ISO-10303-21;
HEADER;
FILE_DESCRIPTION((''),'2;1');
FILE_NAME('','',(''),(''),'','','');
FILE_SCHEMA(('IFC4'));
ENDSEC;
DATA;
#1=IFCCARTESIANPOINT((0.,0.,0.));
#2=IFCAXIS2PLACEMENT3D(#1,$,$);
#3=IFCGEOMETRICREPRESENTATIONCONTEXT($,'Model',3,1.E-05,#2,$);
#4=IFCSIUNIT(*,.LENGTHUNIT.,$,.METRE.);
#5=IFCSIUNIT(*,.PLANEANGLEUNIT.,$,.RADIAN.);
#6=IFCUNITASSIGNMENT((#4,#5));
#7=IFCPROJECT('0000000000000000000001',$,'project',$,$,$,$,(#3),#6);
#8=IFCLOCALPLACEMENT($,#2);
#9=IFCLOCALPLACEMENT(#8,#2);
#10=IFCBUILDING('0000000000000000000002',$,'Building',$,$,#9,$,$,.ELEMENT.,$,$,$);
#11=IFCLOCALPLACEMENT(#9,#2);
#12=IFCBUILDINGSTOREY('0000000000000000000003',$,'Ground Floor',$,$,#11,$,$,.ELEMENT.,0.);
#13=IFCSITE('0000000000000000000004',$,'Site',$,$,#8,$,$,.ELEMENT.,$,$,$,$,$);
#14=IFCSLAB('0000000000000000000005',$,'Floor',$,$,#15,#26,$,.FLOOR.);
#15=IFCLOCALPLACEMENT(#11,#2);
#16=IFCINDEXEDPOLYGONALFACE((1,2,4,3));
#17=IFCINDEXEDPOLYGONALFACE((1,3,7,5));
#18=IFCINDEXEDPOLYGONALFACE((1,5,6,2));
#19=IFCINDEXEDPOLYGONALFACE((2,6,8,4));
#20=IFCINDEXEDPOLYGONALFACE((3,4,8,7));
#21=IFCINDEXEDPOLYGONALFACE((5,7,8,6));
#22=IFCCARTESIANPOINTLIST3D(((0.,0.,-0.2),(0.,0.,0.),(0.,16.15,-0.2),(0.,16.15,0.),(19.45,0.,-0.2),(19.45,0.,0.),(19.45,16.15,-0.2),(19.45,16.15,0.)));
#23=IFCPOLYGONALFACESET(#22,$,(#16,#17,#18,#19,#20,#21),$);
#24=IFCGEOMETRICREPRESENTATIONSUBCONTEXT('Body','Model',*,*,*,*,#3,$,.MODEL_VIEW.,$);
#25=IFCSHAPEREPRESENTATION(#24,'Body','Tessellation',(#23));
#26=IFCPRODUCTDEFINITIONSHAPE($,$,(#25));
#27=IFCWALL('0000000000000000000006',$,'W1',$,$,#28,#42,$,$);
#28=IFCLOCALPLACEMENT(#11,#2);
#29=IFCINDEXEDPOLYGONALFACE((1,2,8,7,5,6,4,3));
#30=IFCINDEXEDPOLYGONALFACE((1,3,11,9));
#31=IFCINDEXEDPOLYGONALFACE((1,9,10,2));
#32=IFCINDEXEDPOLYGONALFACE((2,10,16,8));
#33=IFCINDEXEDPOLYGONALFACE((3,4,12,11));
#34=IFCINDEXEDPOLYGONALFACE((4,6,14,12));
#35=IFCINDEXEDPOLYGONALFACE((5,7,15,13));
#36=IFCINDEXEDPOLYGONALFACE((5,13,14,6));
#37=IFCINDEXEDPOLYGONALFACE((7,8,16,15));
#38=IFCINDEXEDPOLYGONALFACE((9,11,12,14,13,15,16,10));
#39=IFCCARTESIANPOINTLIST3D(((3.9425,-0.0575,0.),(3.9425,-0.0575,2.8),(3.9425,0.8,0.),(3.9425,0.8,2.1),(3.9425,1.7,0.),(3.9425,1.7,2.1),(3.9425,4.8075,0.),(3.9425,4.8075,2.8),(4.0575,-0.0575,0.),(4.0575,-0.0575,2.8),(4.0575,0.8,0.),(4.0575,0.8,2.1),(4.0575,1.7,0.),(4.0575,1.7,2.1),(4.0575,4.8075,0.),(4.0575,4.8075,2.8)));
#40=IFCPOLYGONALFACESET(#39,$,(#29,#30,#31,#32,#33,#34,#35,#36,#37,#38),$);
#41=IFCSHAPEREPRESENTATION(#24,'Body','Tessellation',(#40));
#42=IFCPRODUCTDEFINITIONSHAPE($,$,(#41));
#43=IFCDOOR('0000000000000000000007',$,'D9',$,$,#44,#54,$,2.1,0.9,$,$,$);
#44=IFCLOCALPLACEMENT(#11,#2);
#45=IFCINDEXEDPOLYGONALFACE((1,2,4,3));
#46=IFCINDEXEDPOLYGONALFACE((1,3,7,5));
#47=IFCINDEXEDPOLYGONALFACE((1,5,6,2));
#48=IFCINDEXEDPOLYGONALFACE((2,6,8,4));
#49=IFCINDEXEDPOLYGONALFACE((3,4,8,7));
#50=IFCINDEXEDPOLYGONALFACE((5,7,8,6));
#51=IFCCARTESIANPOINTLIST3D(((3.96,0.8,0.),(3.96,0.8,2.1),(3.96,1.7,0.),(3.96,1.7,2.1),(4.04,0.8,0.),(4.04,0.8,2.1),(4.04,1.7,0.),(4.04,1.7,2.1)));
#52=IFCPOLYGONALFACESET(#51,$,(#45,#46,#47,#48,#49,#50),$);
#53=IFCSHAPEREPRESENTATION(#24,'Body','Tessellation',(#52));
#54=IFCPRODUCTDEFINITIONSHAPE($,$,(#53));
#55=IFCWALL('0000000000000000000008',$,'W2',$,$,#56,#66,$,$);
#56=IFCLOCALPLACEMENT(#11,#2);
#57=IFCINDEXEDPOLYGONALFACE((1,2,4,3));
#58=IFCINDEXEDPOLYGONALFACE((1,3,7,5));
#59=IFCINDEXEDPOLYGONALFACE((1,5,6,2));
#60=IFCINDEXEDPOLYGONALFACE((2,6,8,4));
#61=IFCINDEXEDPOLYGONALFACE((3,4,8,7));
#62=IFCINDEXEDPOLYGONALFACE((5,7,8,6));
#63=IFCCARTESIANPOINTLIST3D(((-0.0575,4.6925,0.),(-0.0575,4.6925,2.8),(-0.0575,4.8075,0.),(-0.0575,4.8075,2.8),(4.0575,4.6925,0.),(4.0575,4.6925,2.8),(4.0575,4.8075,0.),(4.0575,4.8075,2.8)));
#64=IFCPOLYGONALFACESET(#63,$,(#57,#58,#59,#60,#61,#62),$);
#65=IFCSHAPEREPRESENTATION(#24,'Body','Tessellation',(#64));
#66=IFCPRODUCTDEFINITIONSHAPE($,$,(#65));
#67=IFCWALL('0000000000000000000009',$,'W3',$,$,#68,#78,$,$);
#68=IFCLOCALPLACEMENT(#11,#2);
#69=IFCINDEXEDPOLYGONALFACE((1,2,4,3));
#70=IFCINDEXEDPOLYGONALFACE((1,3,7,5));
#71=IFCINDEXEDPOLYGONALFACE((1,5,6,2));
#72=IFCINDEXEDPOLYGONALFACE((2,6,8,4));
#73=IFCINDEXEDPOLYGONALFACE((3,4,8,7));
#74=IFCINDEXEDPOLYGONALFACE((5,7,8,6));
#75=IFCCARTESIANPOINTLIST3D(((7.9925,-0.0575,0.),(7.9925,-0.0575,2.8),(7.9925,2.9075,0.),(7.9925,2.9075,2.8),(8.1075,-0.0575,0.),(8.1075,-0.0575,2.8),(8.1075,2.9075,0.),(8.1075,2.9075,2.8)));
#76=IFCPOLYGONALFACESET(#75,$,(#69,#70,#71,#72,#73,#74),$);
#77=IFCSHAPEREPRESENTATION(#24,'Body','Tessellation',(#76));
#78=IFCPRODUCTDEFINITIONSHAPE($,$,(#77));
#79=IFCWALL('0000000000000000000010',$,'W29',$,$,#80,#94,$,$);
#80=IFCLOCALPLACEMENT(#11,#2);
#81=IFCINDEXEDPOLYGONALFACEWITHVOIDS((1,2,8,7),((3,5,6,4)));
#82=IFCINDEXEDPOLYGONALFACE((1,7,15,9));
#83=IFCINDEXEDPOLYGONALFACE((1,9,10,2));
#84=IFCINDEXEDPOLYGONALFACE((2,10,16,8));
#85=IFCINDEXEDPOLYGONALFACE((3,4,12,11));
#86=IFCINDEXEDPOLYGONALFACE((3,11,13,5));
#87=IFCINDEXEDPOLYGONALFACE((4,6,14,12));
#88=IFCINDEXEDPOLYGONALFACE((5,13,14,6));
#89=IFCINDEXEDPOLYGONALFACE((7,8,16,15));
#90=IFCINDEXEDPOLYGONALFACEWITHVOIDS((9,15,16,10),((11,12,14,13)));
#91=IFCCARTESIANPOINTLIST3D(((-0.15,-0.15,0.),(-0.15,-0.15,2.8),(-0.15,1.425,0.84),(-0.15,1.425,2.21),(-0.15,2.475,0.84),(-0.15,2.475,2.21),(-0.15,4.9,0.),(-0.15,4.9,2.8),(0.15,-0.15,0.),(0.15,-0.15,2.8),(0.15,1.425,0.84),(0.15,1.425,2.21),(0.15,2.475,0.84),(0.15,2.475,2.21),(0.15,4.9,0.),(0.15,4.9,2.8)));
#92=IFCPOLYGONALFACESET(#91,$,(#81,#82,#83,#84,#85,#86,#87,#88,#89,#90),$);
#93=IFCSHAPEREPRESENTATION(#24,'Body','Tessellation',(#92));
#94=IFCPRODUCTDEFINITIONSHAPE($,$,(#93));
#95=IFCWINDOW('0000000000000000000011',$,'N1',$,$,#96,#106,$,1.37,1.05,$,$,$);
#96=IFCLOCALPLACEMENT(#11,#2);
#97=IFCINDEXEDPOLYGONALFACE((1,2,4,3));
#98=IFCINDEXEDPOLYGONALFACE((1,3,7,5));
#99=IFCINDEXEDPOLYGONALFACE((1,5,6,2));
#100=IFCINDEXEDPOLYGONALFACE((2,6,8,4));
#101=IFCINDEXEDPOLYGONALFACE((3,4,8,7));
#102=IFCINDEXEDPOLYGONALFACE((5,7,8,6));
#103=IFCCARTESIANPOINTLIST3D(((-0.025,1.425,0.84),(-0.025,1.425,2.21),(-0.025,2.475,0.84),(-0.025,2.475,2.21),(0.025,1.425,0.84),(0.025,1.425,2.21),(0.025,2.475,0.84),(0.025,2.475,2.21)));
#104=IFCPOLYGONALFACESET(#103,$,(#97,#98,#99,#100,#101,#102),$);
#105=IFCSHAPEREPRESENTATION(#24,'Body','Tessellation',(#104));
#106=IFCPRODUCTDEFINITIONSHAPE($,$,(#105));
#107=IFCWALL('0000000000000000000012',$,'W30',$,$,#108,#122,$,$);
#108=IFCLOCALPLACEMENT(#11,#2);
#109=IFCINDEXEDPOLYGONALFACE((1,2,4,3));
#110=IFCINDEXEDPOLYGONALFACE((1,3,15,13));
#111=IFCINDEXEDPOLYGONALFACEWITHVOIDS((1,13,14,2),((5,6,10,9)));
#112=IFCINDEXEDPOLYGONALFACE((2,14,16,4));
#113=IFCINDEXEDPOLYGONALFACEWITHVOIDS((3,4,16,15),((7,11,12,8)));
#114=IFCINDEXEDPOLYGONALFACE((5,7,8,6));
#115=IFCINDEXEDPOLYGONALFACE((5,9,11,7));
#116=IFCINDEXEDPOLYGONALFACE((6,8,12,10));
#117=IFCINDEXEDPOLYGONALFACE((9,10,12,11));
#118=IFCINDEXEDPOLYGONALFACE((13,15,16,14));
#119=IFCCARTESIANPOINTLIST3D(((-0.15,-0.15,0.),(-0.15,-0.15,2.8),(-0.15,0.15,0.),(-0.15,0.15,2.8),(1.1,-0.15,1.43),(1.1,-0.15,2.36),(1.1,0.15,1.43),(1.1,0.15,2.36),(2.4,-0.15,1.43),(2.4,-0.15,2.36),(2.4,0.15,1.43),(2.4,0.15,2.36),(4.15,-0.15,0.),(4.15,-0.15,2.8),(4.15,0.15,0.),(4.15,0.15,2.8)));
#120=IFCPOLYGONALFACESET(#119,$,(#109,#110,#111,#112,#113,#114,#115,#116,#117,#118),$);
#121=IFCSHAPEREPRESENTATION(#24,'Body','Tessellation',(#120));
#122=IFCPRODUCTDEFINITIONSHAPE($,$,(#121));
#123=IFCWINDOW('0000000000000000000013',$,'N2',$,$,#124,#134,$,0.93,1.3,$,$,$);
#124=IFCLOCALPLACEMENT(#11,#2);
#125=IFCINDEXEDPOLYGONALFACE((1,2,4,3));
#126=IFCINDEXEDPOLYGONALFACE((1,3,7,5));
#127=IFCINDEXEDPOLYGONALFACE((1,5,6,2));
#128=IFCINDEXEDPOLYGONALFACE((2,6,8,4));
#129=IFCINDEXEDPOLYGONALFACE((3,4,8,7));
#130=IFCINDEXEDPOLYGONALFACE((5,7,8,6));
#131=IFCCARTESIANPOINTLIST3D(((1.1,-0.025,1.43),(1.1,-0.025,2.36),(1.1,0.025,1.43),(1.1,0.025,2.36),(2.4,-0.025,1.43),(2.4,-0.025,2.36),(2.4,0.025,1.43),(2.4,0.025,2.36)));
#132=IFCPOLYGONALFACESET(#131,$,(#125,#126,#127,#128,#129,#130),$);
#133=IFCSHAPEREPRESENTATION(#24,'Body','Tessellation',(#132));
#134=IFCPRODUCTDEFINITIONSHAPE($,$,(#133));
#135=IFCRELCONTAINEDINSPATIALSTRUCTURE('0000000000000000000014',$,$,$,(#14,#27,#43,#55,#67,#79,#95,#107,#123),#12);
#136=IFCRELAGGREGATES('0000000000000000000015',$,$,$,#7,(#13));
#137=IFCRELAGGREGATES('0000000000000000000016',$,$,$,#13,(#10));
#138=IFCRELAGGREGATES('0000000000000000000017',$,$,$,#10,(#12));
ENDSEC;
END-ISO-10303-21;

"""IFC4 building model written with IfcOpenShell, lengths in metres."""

from ifc_helpers import new_model, si_unit, frame, frame_2d, origin, origin_2d, place, context, subcontext, project, spatial, polyline, rectangle, outline, extrude, element, fill, save


model = new_model("IFC4")

# Units and contexts
model_context = context("Model", 3, precision=1e-05, world=origin())
body_context = subcontext(model_context, "Body", "Model", "MODEL_VIEW")
ifc_project = project(units=[si_unit("LENGTHUNIT", "METRE"), si_unit("PLANEANGLEUNIT", "RADIAN")], contexts=[model_context])

# Site, building, storey
site_placement = place(None, origin())
site = spatial("IfcSite", under=ifc_project, at=site_placement, Name="Site", CompositionType="ELEMENT")
building_placement = place(site_placement, origin())
building = spatial("IfcBuilding", under=site, at=building_placement, Name="Building", CompositionType="ELEMENT")
storey_placement = place(building_placement, origin())
storey = spatial("IfcBuildingStorey", under=building, at=storey_placement, Name="Ground Floor", CompositionType="ELEMENT", Elevation=0.0)

# Slab
slab_placement = place(storey_placement, origin())
element("IfcSlab", 1, at=slab_placement, inside=storey, Name="Floor", PredefinedType="FLOOR", context=body_context, shape_type="SweptSolid", body=[
    extrude(outline(polyline([(0.0, 0.0), (19.45, 0.0), (19.45, 16.15), (0.0, 16.15), (0.0, 0.0)])), origin(), (0.0, 0.0, -1.0), 0.2),
])

# Wall, opening, door
wall_1_placement = place(storey_placement, frame((4.0, 0.0, 0.0), x_axis=(0.0, 1.0, 0.0)))
wall_1 = element("IfcWall", 2, at=wall_1_placement, inside=storey, Name="W1", context=body_context, shape_type="SweptSolid", body=[
    extrude(rectangle(XDim=4.865, YDim=0.115, at=frame_2d((2.375, 0.0))), origin(), (0.0, 0.0, 1.0), 2.8),
])
opening_1_placement = place(wall_1_placement, frame((1.25, 0.0, 0.0)))
opening_1 = element("IfcOpeningElement", 3, at=opening_1_placement, cuts=wall_1, context=body_context, shape_type="SweptSolid", body=[
    extrude(rectangle(XDim=0.9, YDim=0.215, at=origin_2d()), origin(), (0.0, 0.0, 1.0), 2.1),
])
door_1_placement = place(opening_1_placement, origin())
door_1 = element("IfcDoor", 4, at=door_1_placement, inside=storey, Name="D9", OverallHeight=2.1, OverallWidth=0.9, context=body_context, shape_type="SweptSolid", body=[
    extrude(rectangle(XDim=0.9, YDim=0.08, at=origin_2d()), origin(), (0.0, 0.0, 1.0), 2.1),
])
fill(opening_1, door_1)

# Walls
wall_2_placement = place(storey_placement, frame((0.0, 4.75, 0.0), x_axis=(1.0, 0.0, 0.0)))
element("IfcWall", 5, at=wall_2_placement, inside=storey, Name="W2", context=body_context, shape_type="SweptSolid", body=[
    extrude(rectangle(XDim=4.115, YDim=0.115, at=frame_2d((2.0, 0.0))), origin(), (0.0, 0.0, 1.0), 2.8),
])
wall_3_placement = place(storey_placement, frame((8.05, 0.0, 0.0), x_axis=(0.0, 1.0, 0.0)))
element("IfcWall", 6, at=wall_3_placement, inside=storey, Name="W3", context=body_context, shape_type="SweptSolid", body=[
    extrude(rectangle(XDim=2.965, YDim=0.115, at=frame_2d((1.425, 0.0))), origin(), (0.0, 0.0, 1.0), 2.8),
])

# Walls, openings, windows
wall_4_placement = place(storey_placement, frame((0.0, 0.0, 0.0), x_axis=(0.0, 1.0, 0.0)))
wall_4 = element("IfcWall", 7, at=wall_4_placement, inside=storey, Name="W29", context=body_context, shape_type="SweptSolid", body=[
    extrude(rectangle(XDim=5.05, YDim=0.3, at=frame_2d((2.375, 0.0))), origin(), (0.0, 0.0, 1.0), 2.8),
])
opening_2_placement = place(wall_4_placement, frame((1.95, 0.0, 0.84)))
opening_2 = element("IfcOpeningElement", 8, at=opening_2_placement, cuts=wall_4, context=body_context, shape_type="SweptSolid", body=[
    extrude(rectangle(XDim=1.05, YDim=0.4, at=origin_2d()), origin(), (0.0, 0.0, 1.0), 1.37),
])
window_1_placement = place(opening_2_placement, origin())
window_1 = element("IfcWindow", 9, at=window_1_placement, inside=storey, Name="N1", OverallHeight=1.37, OverallWidth=1.05, context=body_context, shape_type="SweptSolid", body=[
    extrude(rectangle(XDim=1.05, YDim=0.05, at=origin_2d()), origin(), (0.0, 0.0, 1.0), 1.37),
])
fill(opening_2, window_1)
wall_5_placement = place(storey_placement, frame((0.0, 0.0, 0.0), x_axis=(1.0, 0.0, 0.0)))
wall_5 = element("IfcWall", 10, at=wall_5_placement, inside=storey, Name="W30", context=body_context, shape_type="SweptSolid", body=[
    extrude(rectangle(XDim=4.3, YDim=0.3, at=frame_2d((2.0, 0.0))), origin(), (0.0, 0.0, 1.0), 2.8),
])
opening_3_placement = place(wall_5_placement, frame((1.75, 0.0, 1.43)))
opening_3 = element("IfcOpeningElement", 11, at=opening_3_placement, cuts=wall_5, context=body_context, shape_type="SweptSolid", body=[
    extrude(rectangle(XDim=1.3, YDim=0.4, at=origin_2d()), origin(), (0.0, 0.0, 1.0), 0.93),
])
window_2_placement = place(opening_3_placement, origin())
window_2 = element("IfcWindow", 12, at=window_2_placement, inside=storey, Name="N2", OverallHeight=0.93, OverallWidth=1.3, context=body_context, shape_type="SweptSolid", body=[
    extrude(rectangle(XDim=1.3, YDim=0.05, at=origin_2d()), origin(), (0.0, 0.0, 1.0), 0.93),
])
fill(opening_3, window_2)

save(model, "model.ifc")
